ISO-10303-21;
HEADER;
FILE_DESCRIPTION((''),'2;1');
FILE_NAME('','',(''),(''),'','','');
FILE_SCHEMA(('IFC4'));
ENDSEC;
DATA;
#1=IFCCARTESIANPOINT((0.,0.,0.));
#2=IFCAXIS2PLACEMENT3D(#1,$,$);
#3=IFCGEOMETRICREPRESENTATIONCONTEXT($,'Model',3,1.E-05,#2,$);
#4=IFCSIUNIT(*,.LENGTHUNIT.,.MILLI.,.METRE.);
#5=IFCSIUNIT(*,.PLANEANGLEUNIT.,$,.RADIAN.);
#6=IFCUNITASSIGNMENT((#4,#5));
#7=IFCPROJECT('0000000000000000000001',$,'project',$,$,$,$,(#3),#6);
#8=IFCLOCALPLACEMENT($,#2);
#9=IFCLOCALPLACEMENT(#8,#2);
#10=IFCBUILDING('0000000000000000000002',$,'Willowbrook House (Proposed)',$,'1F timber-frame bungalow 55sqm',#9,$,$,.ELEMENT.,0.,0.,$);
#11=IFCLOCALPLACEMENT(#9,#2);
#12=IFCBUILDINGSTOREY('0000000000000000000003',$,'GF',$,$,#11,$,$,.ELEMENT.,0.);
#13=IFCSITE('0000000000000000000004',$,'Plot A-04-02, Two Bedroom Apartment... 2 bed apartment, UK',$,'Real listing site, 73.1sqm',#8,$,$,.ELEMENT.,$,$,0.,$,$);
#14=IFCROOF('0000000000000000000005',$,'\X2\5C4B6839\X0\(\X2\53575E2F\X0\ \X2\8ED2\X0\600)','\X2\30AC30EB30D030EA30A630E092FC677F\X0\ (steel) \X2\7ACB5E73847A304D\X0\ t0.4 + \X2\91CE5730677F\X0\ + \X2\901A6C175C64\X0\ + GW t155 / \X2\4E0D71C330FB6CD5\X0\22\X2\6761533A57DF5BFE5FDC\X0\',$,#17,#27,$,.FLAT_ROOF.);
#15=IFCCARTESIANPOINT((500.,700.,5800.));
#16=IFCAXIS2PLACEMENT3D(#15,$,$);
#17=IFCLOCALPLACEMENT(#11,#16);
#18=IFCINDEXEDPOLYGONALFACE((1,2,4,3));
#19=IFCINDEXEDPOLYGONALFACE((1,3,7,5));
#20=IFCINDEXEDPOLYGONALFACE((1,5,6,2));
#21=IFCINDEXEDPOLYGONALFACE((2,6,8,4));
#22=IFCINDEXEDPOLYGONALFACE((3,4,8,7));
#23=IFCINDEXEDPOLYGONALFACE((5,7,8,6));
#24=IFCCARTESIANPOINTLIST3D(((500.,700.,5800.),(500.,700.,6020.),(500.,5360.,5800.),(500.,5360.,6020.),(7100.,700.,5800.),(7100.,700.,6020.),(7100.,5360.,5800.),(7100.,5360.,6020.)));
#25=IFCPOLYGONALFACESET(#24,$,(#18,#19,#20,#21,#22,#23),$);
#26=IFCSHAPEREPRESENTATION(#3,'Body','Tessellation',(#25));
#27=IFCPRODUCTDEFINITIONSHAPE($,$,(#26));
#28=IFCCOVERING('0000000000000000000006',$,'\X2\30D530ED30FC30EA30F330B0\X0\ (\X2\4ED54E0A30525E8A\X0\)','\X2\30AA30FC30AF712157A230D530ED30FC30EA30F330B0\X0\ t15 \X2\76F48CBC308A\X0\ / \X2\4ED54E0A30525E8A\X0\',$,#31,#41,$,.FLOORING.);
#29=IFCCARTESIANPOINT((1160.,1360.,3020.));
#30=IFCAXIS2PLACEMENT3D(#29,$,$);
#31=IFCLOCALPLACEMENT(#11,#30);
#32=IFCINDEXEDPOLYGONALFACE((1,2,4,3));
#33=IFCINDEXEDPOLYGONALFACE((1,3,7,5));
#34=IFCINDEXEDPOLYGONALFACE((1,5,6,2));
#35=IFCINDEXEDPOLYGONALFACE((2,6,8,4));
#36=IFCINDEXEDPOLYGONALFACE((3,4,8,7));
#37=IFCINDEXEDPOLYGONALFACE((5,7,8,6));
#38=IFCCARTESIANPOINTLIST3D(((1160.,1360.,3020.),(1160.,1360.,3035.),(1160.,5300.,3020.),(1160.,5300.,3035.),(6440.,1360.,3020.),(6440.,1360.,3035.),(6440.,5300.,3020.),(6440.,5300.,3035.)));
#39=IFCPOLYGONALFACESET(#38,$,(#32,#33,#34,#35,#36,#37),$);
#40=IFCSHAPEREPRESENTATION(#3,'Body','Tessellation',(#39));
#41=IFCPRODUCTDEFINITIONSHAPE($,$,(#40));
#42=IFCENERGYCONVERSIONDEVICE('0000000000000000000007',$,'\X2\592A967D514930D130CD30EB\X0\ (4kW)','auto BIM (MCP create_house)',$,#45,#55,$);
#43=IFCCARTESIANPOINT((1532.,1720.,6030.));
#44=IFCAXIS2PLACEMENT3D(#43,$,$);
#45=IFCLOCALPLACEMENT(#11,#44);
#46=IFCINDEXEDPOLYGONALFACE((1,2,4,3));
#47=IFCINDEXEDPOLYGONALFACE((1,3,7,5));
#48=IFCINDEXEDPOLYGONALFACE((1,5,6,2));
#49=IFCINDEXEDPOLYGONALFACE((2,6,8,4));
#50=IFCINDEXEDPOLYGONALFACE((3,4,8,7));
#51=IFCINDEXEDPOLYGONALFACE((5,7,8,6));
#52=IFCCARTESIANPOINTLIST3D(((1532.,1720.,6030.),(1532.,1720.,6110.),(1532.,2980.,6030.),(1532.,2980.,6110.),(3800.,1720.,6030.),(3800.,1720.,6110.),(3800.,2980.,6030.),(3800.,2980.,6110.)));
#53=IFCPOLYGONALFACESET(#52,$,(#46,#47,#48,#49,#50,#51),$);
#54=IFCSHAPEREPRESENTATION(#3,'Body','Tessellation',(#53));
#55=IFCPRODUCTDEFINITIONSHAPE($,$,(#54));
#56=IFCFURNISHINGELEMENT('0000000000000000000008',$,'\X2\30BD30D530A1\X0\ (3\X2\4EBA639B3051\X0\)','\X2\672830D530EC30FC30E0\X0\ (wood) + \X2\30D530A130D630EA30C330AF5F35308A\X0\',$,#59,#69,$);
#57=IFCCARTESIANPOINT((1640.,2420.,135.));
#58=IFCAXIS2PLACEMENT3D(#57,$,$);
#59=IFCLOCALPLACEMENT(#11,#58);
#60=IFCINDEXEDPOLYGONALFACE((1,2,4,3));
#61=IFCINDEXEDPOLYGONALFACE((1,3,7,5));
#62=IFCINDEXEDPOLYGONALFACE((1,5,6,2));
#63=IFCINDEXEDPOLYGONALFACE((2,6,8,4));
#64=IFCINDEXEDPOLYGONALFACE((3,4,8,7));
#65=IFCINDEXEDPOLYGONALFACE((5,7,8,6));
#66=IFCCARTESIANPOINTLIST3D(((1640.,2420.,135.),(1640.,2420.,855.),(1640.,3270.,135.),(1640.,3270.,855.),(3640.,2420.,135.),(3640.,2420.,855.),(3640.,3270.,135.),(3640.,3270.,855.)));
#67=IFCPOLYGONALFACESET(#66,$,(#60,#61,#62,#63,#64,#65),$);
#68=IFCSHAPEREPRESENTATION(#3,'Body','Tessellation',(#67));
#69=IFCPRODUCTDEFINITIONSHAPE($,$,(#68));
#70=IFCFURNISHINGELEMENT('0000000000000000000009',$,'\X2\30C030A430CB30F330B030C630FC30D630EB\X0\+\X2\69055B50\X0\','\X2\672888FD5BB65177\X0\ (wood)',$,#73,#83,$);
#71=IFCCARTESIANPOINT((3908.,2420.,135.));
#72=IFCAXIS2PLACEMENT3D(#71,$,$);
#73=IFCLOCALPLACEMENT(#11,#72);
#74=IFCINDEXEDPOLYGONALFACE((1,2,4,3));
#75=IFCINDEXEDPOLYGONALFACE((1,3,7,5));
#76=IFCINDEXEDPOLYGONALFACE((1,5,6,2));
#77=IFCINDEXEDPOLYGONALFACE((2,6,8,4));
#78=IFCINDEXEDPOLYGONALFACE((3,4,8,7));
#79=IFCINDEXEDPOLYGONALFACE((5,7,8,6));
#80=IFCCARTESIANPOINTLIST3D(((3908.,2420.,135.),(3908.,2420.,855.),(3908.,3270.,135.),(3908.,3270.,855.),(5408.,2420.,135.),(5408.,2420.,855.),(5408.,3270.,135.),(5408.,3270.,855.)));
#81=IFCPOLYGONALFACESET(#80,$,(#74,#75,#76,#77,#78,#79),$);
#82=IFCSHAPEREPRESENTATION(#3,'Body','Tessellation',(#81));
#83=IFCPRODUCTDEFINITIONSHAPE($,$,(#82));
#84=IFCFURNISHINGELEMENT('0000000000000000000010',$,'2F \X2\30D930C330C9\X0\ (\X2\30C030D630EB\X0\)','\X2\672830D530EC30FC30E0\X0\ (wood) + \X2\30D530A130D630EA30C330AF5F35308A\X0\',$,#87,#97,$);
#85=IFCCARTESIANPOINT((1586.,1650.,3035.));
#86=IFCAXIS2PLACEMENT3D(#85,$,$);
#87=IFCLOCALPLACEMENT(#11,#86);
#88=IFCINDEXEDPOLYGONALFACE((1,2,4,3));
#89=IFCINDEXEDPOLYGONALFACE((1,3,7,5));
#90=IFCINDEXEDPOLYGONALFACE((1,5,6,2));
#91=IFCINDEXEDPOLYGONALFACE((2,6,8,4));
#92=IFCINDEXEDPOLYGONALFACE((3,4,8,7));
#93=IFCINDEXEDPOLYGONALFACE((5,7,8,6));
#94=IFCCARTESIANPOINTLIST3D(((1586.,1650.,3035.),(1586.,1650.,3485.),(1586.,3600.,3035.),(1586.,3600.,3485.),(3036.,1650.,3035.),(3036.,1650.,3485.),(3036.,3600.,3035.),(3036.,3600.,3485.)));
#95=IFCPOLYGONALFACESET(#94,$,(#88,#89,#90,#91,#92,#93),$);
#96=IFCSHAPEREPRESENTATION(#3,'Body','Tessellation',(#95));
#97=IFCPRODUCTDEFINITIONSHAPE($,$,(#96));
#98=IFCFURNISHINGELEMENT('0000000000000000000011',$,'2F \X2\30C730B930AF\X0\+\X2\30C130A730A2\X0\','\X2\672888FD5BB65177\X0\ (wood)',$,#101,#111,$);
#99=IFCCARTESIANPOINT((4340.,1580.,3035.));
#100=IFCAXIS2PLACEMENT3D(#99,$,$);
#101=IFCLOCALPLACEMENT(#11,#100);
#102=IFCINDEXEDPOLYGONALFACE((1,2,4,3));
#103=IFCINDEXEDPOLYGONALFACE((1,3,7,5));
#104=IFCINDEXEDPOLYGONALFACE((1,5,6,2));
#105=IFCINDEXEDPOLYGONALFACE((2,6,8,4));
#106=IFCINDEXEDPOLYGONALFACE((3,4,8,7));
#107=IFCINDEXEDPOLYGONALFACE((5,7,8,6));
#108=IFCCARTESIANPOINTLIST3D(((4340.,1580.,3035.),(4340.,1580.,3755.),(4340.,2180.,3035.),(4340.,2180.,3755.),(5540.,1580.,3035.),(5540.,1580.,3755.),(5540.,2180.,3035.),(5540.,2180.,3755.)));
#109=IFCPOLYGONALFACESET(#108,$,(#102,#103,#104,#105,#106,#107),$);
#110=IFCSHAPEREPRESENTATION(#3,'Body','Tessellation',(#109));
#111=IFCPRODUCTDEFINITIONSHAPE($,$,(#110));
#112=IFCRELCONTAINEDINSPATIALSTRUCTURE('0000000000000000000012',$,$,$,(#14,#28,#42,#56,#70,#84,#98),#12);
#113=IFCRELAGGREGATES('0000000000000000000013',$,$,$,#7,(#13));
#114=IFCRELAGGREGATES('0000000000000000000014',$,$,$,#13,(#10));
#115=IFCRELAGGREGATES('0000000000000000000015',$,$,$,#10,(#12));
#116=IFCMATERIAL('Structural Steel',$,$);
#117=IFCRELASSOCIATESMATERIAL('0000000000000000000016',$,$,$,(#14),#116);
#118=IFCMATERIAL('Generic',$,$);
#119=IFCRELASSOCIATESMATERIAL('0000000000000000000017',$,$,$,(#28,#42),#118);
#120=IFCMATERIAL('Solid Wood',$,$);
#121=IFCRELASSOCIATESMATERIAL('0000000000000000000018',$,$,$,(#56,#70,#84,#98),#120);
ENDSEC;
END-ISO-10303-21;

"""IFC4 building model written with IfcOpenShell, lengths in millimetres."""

from ifc_helpers import new_model, si_unit, frame, frame_2d, origin, place, context, project, spatial, rectangle, extrude, material, element, save


model = new_model("IFC4")

# Units and contexts
model_context = context("Model", 3, precision=1e-05, world=origin())
ifc_project = project(units=[si_unit("LENGTHUNIT", "METRE", prefix="MILLI"), si_unit("PLANEANGLEUNIT", "RADIAN")], contexts=[model_context])

# Site, building, storey
site_placement = place(None, origin())
site = spatial("IfcSite", under=ifc_project, at=site_placement, Name="Plot A-04-02, Two Bedroom Apartment... 2 bed apartment, UK", ObjectType="Real listing site, 73.1sqm", CompositionType="ELEMENT", RefElevation=0.0)
building_placement = place(site_placement, origin())
building = spatial("IfcBuilding", under=site, at=building_placement, Name="Willowbrook House (Proposed)", ObjectType="1F timber-frame bungalow 55sqm", CompositionType="ELEMENT", ElevationOfRefHeight=0.0, ElevationOfTerrain=0.0)
storey_placement = place(building_placement, origin())
storey = spatial("IfcBuildingStorey", under=building, at=storey_placement, Name="GF", CompositionType="ELEMENT", Elevation=0.0)

# Shared definitions
ifc_material_1 = material(Name="Solid Wood")

# Shared definitions
ifc_material_2 = material(Name="Generic")

# Roof
ifc_material_3 = material(Name="Structural Steel")
for number, where, name in (
    (1, (500.0, 700.0, 5800.0), "屋根(南帯 軒600)"),
):
    element("IfcRoof", number, at=place(storey_placement, frame(where)), inside=storey, material=ifc_material_3, Name=name, Description="ガルバリウム鋼板 (steel) 立平葺き t0.4 + 野地板 + 通気層 + GW t155 / 不燃・法22条区域対応", PredefinedType="FLAT_ROOF", context=model_context, shape_type="SweptSolid", body=[
        extrude(rectangle(XDim=6600.0, YDim=4660.0, at=frame_2d((3300.0, 2330.0))), frame((500.0, 700.0, 5800.0)), (0.0, 0.0, 1.0), 220.0),
    ])

# Covering
covering_placement = place(storey_placement, frame((1160.0, 1360.0, 3020.0)))
element("IfcCovering", 2, at=covering_placement, inside=storey, material=ifc_material_2, Name="フローリング (仕上げ床)", Description="オーク無垢フローリング t15 直貼り / 仕上げ床", PredefinedType="FLOORING", context=model_context, shape_type="SweptSolid", body=[
    extrude(rectangle(XDim=5280.0, YDim=3940.0, at=frame_2d((2640.0, 1970.0))), frame((1160.0, 1360.0, 3020.0)), (0.0, 0.0, 1.0), 15.0),
])

# Energy conversion device
energy_conversion_device_placement = place(storey_placement, frame((1532.0, 1720.0, 6030.0)))
element("IfcEnergyConversionDevice", 3, at=energy_conversion_device_placement, inside=storey, material=ifc_material_2, Name="太陽光パネル (4kW)", Description="auto BIM (MCP create_house)", context=model_context, shape_type="SweptSolid", body=[
    extrude(rectangle(XDim=2268.0, YDim=1260.0, at=frame_2d((1134.0, 630.0))), frame((1532.0, 1720.0, 6030.0)), (0.0, 0.0, 1.0), 80.0),
])

# Furnishing elements
furnishing_1_placement = place(storey_placement, frame((1640.0, 2420.0, 135.0)))
element("IfcFurnishingElement", 4, at=furnishing_1_placement, inside=storey, material=ifc_material_1, Name="ソファ (3人掛け)", Description="木フレーム (wood) + ファブリック張り", context=model_context, shape_type="SweptSolid", body=[
    extrude(rectangle(XDim=2000.0, YDim=850.0, at=frame_2d((1000.0, 425.0))), frame((1640.0, 2420.0, 135.0)), (0.0, 0.0, 1.0), 720.0),
])
furnishing_2_placement = place(storey_placement, frame((3908.0, 2420.0, 135.0)))
element("IfcFurnishingElement", 5, at=furnishing_2_placement, inside=storey, material=ifc_material_1, Name="ダイニングテーブル+椅子", Description="木製家具 (wood)", context=model_context, shape_type="SweptSolid", body=[
    extrude(rectangle(XDim=1500.0, YDim=850.0, at=frame_2d((750.0, 425.0))), frame((3908.0, 2420.0, 135.0)), (0.0, 0.0, 1.0), 720.0),
])
furnishing_3_placement = place(storey_placement, frame((1586.0, 1650.0, 3035.0)))
element("IfcFurnishingElement", 6, at=furnishing_3_placement, inside=storey, material=ifc_material_1, Name="2F ベッド (ダブル)", Description="木フレーム (wood) + ファブリック張り", context=model_context, shape_type="SweptSolid", body=[
    extrude(rectangle(XDim=1450.0, YDim=1950.0, at=frame_2d((725.0, 975.0))), frame((1586.0, 1650.0, 3035.0)), (0.0, 0.0, 1.0), 450.0),
])
furnishing_4_placement = place(storey_placement, frame((4340.0, 1580.0, 3035.0)))
element("IfcFurnishingElement", 7, at=furnishing_4_placement, inside=storey, material=ifc_material_1, Name="2F デスク+チェア", Description="木製家具 (wood)", context=model_context, shape_type="SweptSolid", body=[
    extrude(rectangle(XDim=1200.0, YDim=600.0, at=frame_2d((600.0, 300.0))), frame((4340.0, 1580.0, 3035.0)), (0.0, 0.0, 1.0), 720.0),
])

save(model, "model.ifc")
